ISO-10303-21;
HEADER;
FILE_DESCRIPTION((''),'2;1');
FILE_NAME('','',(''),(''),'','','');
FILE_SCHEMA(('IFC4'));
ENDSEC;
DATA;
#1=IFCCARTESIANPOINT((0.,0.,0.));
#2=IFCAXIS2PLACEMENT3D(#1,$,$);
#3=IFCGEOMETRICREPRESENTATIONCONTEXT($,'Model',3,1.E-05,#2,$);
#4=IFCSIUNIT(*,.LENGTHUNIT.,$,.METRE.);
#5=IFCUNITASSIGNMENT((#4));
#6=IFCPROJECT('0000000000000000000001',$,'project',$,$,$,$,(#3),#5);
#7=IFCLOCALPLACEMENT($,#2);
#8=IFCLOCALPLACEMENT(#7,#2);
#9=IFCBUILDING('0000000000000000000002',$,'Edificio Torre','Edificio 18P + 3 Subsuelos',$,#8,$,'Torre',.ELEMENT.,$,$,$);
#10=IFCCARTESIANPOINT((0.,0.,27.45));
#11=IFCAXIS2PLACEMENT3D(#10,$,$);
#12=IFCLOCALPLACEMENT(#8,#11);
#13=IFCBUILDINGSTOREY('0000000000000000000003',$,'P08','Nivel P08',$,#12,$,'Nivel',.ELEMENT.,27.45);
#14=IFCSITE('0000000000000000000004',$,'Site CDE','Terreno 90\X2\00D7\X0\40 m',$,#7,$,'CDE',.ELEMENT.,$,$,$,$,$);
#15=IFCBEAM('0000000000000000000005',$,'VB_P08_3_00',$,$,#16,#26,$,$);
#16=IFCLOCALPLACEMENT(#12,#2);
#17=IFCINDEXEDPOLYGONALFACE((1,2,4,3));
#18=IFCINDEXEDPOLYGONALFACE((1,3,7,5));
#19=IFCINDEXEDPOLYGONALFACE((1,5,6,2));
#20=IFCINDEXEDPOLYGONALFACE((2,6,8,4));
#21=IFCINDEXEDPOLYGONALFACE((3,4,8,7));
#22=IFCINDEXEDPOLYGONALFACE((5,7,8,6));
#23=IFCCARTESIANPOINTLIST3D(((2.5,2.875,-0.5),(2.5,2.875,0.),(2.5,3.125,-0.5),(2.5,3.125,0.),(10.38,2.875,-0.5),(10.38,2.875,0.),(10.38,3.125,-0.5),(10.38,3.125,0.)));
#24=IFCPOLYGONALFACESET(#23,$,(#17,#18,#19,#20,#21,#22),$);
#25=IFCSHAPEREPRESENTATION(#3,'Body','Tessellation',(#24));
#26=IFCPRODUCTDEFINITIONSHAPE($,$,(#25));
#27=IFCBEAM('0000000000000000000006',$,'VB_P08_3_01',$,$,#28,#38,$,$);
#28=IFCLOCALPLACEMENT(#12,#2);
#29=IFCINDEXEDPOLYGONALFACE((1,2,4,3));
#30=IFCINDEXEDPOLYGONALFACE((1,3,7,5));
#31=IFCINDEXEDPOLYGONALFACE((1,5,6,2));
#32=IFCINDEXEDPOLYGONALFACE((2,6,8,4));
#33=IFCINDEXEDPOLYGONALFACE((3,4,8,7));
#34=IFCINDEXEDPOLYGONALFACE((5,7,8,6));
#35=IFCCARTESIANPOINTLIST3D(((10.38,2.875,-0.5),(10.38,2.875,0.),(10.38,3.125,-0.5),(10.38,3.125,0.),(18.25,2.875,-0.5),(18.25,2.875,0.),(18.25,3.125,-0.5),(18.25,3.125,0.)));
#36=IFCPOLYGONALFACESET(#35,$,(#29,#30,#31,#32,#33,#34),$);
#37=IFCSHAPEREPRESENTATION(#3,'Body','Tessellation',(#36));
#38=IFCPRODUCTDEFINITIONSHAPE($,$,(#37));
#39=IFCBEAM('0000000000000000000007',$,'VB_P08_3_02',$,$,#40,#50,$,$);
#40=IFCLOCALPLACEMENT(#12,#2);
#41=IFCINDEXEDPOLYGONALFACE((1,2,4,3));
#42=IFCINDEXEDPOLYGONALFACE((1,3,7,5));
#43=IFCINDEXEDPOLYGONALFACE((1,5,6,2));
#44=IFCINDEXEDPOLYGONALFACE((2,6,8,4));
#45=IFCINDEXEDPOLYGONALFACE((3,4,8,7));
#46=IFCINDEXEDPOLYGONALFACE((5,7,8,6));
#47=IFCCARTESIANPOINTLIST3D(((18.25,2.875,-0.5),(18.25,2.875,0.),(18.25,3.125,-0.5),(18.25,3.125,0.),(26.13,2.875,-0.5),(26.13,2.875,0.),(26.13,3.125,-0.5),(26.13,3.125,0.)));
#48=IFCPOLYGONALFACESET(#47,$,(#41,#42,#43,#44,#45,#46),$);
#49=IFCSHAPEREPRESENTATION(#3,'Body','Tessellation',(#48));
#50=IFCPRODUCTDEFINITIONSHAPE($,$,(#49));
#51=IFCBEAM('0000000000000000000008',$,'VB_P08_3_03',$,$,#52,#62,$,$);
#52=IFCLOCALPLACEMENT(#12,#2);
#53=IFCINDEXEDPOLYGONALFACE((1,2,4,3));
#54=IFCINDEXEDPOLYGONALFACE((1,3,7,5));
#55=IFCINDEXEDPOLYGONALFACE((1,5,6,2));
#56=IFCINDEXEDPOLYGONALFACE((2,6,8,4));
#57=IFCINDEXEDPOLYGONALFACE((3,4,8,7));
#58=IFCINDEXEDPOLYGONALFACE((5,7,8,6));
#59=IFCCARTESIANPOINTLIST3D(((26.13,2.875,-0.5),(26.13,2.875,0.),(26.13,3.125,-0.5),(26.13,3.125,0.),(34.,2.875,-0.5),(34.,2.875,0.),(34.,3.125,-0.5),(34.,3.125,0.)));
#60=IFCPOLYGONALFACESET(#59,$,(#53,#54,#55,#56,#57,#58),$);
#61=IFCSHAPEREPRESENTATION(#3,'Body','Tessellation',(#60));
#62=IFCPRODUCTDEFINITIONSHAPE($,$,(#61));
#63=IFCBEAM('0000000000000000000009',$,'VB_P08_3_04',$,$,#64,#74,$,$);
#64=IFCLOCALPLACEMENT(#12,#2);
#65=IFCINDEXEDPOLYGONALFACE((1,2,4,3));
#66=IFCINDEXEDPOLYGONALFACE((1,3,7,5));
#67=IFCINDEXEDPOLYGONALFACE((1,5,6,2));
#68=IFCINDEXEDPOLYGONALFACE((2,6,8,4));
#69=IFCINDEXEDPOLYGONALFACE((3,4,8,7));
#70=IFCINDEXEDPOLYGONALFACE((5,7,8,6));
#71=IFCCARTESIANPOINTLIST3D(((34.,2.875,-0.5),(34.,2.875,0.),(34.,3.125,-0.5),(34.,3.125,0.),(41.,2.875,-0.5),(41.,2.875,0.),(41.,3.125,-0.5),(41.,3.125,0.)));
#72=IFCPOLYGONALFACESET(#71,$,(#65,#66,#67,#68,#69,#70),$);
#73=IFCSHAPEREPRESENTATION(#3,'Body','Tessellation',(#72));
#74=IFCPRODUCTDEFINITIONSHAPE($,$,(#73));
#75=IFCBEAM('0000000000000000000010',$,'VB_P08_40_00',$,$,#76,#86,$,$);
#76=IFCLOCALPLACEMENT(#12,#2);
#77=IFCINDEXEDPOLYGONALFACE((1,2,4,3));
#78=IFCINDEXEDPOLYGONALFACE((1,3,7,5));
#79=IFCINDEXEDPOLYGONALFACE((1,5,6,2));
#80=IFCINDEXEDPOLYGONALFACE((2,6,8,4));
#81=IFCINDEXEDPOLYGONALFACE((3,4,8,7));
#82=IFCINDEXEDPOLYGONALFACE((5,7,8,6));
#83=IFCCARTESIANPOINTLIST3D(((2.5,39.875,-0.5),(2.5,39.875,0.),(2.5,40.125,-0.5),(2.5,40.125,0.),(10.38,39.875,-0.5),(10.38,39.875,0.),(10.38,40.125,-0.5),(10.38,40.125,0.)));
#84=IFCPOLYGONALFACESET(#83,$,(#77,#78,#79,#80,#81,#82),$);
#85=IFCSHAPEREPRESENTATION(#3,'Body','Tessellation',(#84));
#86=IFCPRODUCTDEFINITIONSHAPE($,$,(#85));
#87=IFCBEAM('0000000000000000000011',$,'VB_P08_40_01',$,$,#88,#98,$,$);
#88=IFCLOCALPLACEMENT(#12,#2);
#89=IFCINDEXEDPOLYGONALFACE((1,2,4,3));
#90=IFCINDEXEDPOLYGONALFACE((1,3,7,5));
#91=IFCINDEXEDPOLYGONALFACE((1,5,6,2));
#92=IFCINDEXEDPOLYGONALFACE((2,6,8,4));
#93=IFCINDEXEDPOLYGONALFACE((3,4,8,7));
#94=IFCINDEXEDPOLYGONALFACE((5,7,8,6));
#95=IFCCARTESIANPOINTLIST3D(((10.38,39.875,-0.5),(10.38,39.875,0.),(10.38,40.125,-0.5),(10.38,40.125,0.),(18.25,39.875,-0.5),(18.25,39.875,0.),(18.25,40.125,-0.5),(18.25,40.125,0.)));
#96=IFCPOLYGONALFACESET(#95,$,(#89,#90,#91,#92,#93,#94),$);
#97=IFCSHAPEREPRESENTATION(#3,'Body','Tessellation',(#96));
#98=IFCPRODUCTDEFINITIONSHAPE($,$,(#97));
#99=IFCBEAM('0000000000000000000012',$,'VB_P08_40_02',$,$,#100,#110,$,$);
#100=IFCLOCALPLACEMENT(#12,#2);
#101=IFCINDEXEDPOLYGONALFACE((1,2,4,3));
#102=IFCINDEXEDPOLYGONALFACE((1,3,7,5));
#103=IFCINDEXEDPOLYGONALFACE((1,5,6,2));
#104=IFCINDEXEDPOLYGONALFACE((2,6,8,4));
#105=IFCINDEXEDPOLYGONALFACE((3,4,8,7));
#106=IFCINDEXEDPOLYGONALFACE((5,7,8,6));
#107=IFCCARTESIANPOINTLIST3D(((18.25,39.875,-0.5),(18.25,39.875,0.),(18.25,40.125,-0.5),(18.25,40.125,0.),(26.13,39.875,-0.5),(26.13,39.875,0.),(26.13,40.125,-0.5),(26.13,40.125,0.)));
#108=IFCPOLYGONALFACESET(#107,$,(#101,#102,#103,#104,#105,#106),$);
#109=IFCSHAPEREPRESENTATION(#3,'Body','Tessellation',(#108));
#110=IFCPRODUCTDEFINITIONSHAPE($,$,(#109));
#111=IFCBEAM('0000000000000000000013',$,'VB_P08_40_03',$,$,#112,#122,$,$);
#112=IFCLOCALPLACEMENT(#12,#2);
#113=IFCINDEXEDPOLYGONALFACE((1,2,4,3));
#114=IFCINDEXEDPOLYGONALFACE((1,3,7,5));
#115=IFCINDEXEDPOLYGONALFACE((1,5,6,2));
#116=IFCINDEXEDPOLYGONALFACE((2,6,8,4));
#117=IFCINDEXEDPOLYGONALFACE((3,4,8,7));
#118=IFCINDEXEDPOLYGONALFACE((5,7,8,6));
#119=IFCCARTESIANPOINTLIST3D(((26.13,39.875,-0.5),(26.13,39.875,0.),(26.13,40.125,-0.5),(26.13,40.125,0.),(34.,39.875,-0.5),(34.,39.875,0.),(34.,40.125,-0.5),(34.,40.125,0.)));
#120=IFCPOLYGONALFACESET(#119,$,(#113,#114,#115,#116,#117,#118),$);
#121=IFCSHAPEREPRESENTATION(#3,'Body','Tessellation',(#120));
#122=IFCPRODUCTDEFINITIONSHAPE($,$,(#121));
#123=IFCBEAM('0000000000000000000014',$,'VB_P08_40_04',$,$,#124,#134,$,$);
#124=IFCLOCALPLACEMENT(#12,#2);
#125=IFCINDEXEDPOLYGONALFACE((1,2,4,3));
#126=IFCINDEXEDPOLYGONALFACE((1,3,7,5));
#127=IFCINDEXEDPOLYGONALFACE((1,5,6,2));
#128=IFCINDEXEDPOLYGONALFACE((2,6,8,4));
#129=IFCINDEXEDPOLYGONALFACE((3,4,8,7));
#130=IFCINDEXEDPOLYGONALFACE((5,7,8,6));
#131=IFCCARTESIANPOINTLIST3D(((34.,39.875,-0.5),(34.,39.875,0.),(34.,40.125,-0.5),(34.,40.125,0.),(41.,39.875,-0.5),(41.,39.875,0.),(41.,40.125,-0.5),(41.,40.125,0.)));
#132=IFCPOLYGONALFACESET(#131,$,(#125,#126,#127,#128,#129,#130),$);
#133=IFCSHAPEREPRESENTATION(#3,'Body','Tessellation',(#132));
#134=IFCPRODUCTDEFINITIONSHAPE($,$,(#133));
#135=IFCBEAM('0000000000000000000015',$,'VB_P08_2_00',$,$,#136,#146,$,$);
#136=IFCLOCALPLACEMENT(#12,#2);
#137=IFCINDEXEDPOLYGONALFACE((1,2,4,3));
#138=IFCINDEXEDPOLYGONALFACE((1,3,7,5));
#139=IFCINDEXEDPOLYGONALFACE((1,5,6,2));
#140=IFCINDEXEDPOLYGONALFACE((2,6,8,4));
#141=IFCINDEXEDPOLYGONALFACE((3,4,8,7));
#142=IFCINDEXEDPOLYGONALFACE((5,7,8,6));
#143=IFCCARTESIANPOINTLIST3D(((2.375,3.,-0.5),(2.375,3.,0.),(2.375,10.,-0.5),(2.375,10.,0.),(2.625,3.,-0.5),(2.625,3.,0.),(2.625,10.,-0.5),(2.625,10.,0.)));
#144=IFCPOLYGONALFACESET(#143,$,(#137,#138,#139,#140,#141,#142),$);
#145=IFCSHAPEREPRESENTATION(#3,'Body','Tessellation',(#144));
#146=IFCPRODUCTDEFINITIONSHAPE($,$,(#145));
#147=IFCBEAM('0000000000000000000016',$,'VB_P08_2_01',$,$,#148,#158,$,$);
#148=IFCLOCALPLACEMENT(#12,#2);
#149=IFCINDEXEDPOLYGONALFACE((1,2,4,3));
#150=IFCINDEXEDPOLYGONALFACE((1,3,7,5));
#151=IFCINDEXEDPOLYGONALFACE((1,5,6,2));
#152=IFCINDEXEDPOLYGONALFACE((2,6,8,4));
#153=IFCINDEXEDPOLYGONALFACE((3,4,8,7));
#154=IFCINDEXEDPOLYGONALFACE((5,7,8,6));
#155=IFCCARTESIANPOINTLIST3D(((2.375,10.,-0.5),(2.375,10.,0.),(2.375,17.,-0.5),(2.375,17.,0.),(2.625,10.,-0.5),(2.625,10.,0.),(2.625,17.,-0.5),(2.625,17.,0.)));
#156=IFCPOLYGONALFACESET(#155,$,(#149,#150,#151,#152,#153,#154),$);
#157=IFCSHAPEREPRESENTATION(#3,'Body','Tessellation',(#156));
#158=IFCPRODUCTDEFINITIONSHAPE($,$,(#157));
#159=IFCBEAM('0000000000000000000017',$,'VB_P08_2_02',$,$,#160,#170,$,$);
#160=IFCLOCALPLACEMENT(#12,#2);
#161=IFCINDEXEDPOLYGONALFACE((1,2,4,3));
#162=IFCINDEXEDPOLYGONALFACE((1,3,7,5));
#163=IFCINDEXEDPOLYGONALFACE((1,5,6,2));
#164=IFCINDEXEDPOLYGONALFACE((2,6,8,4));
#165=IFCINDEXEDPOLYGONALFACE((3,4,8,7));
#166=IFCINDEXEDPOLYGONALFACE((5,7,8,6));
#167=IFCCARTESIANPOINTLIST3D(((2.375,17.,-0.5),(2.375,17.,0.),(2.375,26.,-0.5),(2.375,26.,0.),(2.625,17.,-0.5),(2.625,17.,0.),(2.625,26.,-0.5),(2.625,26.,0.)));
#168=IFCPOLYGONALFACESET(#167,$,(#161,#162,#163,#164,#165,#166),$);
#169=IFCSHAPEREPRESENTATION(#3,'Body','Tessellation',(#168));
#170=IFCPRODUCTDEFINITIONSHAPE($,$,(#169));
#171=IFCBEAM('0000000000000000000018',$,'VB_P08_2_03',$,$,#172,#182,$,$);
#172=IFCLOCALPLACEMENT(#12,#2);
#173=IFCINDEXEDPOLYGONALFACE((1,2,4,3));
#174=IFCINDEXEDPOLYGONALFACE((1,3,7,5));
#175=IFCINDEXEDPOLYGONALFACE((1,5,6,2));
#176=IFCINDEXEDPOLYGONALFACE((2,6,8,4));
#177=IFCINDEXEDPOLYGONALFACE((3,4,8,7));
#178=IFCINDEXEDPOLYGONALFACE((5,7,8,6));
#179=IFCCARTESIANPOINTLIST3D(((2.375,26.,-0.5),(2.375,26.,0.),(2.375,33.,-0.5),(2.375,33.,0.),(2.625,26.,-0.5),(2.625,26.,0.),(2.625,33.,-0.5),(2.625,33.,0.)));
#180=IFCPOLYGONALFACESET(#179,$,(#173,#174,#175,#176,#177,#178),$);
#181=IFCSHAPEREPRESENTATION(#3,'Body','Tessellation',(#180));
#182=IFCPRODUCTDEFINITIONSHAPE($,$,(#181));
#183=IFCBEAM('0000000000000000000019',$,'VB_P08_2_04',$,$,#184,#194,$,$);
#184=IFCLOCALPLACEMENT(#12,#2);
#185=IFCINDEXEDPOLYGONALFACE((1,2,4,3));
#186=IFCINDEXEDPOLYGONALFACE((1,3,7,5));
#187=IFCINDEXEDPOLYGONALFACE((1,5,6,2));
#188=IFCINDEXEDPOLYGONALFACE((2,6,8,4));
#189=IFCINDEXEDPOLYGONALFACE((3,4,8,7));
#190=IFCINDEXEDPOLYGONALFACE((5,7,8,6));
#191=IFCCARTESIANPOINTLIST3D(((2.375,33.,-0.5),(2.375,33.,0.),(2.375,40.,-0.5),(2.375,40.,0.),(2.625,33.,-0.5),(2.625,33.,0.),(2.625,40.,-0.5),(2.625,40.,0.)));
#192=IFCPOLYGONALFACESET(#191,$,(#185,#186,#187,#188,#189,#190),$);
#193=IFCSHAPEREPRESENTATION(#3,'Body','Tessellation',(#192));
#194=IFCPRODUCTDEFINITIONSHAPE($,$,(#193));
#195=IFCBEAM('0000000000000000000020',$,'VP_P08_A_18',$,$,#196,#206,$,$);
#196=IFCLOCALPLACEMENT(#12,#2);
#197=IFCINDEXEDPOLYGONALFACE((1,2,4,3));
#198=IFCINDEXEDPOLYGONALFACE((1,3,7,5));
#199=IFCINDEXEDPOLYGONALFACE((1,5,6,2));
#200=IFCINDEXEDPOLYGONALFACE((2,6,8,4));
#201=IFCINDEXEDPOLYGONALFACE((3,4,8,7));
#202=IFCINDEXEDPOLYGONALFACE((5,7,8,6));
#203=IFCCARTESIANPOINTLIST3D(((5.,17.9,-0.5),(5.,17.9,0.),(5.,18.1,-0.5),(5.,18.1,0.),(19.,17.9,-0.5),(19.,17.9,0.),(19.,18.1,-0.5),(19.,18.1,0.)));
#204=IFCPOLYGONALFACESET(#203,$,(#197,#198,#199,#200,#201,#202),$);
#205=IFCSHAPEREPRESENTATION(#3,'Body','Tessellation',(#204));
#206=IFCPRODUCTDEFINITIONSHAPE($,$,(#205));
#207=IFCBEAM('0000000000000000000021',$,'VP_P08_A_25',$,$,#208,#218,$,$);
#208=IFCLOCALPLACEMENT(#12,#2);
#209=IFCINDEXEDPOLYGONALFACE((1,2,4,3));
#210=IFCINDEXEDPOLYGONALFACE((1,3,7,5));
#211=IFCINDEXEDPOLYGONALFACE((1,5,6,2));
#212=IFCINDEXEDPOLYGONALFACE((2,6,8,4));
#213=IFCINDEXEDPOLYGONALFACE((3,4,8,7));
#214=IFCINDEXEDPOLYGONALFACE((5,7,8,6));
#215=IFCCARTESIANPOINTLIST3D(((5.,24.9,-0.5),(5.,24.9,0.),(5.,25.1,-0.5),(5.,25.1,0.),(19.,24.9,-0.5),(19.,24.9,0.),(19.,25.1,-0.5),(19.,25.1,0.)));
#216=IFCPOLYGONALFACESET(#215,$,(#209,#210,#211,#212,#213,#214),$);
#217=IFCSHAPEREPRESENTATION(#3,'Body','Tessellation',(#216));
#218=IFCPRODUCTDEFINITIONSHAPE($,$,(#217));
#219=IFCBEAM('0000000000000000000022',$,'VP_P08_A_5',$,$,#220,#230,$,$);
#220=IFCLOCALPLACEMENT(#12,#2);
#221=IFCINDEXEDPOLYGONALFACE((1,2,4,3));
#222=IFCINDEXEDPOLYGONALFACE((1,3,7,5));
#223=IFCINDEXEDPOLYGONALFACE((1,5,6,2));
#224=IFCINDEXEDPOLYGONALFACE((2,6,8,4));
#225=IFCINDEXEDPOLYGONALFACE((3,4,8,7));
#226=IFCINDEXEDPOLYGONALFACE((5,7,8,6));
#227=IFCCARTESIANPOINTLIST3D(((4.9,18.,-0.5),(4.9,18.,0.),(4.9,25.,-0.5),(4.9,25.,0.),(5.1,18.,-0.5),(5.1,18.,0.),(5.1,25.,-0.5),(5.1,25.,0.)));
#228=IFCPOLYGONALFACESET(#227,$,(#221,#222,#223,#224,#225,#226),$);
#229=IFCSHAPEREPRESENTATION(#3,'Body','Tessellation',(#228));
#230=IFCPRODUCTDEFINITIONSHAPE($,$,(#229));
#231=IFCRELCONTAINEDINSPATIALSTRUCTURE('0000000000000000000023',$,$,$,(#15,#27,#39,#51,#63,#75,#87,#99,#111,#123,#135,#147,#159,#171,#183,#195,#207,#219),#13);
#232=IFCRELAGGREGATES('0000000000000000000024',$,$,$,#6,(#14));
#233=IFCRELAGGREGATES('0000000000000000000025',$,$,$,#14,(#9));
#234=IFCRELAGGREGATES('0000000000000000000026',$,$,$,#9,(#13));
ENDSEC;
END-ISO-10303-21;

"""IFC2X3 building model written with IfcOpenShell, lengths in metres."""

from ifc_helpers import new_model, si_unit, frame, origin, origin_2d, place, context, project, spatial, rectangle, extrude, element, save


model = new_model("IFC2X3")

# Units and contexts
model_context = context("Model", 3, precision=1e-05, world=origin())
ifc_project = project(units=[si_unit("LENGTHUNIT", "METRE")], contexts=[model_context])

# Site, building, storey
site_placement = place(None, origin())
site = spatial("IfcSite", under=ifc_project, at=site_placement, Name="Site CDE", Description="Terreno 90×40 m", LongName="CDE", CompositionType="ELEMENT")
building_placement = place(site_placement, origin())
building = spatial("IfcBuilding", under=site, at=building_placement, Name="Edificio Torre", Description="Edificio 18P + 3 Subsuelos", LongName="Torre", CompositionType="ELEMENT")
storey_placement = place(building_placement, frame((0.0, 0.0, 27.45)))
storey = spatial("IfcBuildingStorey", under=building, at=storey_placement, Name="P08", Description="Nivel P08", LongName="Nivel", CompositionType="ELEMENT", Elevation=27.45)

# Beams
beam_1_placement = place(storey_placement, frame((6.44, 3.0, -0.5)))
element("IfcBeam", 1, at=beam_1_placement, inside=storey, Name="VB_P08_3_00", context=model_context, shape_type="SweptSolid", body=[
    extrude(rectangle(XDim=7.88, YDim=0.25, at=origin_2d()), origin(), (0.0, 0.0, 1.0), 0.5),
])
beam_2_placement = place(storey_placement, frame((14.315, 3.0, -0.5)))
element("IfcBeam", 2, at=beam_2_placement, inside=storey, Name="VB_P08_3_01", context=model_context, shape_type="SweptSolid", body=[
    extrude(rectangle(XDim=7.87, YDim=0.25, at=origin_2d()), origin(), (0.0, 0.0, 1.0), 0.5),
])
beam_3_placement = place(storey_placement, frame((22.19, 3.0, -0.5)))
element("IfcBeam", 3, at=beam_3_placement, inside=storey, Name="VB_P08_3_02", context=model_context, shape_type="SweptSolid", body=[
    extrude(rectangle(XDim=7.88, YDim=0.25, at=origin_2d()), origin(), (0.0, 0.0, 1.0), 0.5),
])
beam_4_placement = place(storey_placement, frame((30.065, 3.0, -0.5)))
element("IfcBeam", 4, at=beam_4_placement, inside=storey, Name="VB_P08_3_03", context=model_context, shape_type="SweptSolid", body=[
    extrude(rectangle(XDim=7.87, YDim=0.25, at=origin_2d()), origin(), (0.0, 0.0, 1.0), 0.5),
])
beam_5_placement = place(storey_placement, frame((37.5, 3.0, -0.5)))
element("IfcBeam", 5, at=beam_5_placement, inside=storey, Name="VB_P08_3_04", context=model_context, shape_type="SweptSolid", body=[
    extrude(rectangle(XDim=7.0, YDim=0.25, at=origin_2d()), origin(), (0.0, 0.0, 1.0), 0.5),
])
beam_6_placement = place(storey_placement, frame((6.44, 40.0, -0.5)))
element("IfcBeam", 6, at=beam_6_placement, inside=storey, Name="VB_P08_40_00", context=model_context, shape_type="SweptSolid", body=[
    extrude(rectangle(XDim=7.88, YDim=0.25, at=origin_2d()), origin(), (0.0, 0.0, 1.0), 0.5),
])
beam_7_placement = place(storey_placement, frame((14.315, 40.0, -0.5)))
element("IfcBeam", 7, at=beam_7_placement, inside=storey, Name="VB_P08_40_01", context=model_context, shape_type="SweptSolid", body=[
    extrude(rectangle(XDim=7.87, YDim=0.25, at=origin_2d()), origin(), (0.0, 0.0, 1.0), 0.5),
])
beam_8_placement = place(storey_placement, frame((22.19, 40.0, -0.5)))
element("IfcBeam", 8, at=beam_8_placement, inside=storey, Name="VB_P08_40_02", context=model_context, shape_type="SweptSolid", body=[
    extrude(rectangle(XDim=7.88, YDim=0.25, at=origin_2d()), origin(), (0.0, 0.0, 1.0), 0.5),
])
beam_9_placement = place(storey_placement, frame((30.065, 40.0, -0.5)))
element("IfcBeam", 9, at=beam_9_placement, inside=storey, Name="VB_P08_40_03", context=model_context, shape_type="SweptSolid", body=[
    extrude(rectangle(XDim=7.87, YDim=0.25, at=origin_2d()), origin(), (0.0, 0.0, 1.0), 0.5),
])
beam_10_placement = place(storey_placement, frame((37.5, 40.0, -0.5)))
element("IfcBeam", 10, at=beam_10_placement, inside=storey, Name="VB_P08_40_04", context=model_context, shape_type="SweptSolid", body=[
    extrude(rectangle(XDim=7.0, YDim=0.25, at=origin_2d()), origin(), (0.0, 0.0, 1.0), 0.5),
])
for number, where, name in (
    (11, (2.5, 6.5, -0.5), "VB_P08_2_00"),
    (12, (2.5, 13.5, -0.5), "VB_P08_2_01"),
):
    element("IfcBeam", number, at=place(storey_placement, frame(where)), inside=storey, Name=name, context=model_context, shape_type="SweptSolid", body=[
        extrude(rectangle(XDim=0.25, YDim=7.0, at=origin_2d()), origin(), (0.0, 0.0, 1.0), 0.5),
    ])
beam_11_placement = place(storey_placement, frame((2.5, 21.5, -0.5)))
element("IfcBeam", 13, at=beam_11_placement, inside=storey, Name="VB_P08_2_02", context=model_context, shape_type="SweptSolid", body=[
    extrude(rectangle(XDim=0.25, YDim=9.0, at=origin_2d()), origin(), (0.0, 0.0, 1.0), 0.5),
])
for number, where, name in (
    (14, (2.5, 29.5, -0.5), "VB_P08_2_03"),
    (15, (2.5, 36.5, -0.5), "VB_P08_2_04"),
):
    element("IfcBeam", number, at=place(storey_placement, frame(where)), inside=storey, Name=name, context=model_context, shape_type="SweptSolid", body=[
        extrude(rectangle(XDim=0.25, YDim=7.0, at=origin_2d()), origin(), (0.0, 0.0, 1.0), 0.5),
    ])
for number, where, name in (
    (16, (12.0, 18.0, -0.5), "VP_P08_A_18"),
    (17, (12.0, 25.0, -0.5), "VP_P08_A_25"),
):
    element("IfcBeam", number, at=place(storey_placement, frame(where)), inside=storey, Name=name, context=model_context, shape_type="SweptSolid", body=[
        extrude(rectangle(XDim=14.0, YDim=0.2, at=origin_2d()), origin(), (0.0, 0.0, 1.0), 0.5),
    ])
beam_12_placement = place(storey_placement, frame((5.0, 21.5, -0.5)))
element("IfcBeam", 18, at=beam_12_placement, inside=storey, Name="VP_P08_A_5", context=model_context, shape_type="SweptSolid", body=[
    extrude(rectangle(XDim=0.2, YDim=7.0, at=origin_2d()), origin(), (0.0, 0.0, 1.0), 0.5),
])

save(model, "model.ifc")
